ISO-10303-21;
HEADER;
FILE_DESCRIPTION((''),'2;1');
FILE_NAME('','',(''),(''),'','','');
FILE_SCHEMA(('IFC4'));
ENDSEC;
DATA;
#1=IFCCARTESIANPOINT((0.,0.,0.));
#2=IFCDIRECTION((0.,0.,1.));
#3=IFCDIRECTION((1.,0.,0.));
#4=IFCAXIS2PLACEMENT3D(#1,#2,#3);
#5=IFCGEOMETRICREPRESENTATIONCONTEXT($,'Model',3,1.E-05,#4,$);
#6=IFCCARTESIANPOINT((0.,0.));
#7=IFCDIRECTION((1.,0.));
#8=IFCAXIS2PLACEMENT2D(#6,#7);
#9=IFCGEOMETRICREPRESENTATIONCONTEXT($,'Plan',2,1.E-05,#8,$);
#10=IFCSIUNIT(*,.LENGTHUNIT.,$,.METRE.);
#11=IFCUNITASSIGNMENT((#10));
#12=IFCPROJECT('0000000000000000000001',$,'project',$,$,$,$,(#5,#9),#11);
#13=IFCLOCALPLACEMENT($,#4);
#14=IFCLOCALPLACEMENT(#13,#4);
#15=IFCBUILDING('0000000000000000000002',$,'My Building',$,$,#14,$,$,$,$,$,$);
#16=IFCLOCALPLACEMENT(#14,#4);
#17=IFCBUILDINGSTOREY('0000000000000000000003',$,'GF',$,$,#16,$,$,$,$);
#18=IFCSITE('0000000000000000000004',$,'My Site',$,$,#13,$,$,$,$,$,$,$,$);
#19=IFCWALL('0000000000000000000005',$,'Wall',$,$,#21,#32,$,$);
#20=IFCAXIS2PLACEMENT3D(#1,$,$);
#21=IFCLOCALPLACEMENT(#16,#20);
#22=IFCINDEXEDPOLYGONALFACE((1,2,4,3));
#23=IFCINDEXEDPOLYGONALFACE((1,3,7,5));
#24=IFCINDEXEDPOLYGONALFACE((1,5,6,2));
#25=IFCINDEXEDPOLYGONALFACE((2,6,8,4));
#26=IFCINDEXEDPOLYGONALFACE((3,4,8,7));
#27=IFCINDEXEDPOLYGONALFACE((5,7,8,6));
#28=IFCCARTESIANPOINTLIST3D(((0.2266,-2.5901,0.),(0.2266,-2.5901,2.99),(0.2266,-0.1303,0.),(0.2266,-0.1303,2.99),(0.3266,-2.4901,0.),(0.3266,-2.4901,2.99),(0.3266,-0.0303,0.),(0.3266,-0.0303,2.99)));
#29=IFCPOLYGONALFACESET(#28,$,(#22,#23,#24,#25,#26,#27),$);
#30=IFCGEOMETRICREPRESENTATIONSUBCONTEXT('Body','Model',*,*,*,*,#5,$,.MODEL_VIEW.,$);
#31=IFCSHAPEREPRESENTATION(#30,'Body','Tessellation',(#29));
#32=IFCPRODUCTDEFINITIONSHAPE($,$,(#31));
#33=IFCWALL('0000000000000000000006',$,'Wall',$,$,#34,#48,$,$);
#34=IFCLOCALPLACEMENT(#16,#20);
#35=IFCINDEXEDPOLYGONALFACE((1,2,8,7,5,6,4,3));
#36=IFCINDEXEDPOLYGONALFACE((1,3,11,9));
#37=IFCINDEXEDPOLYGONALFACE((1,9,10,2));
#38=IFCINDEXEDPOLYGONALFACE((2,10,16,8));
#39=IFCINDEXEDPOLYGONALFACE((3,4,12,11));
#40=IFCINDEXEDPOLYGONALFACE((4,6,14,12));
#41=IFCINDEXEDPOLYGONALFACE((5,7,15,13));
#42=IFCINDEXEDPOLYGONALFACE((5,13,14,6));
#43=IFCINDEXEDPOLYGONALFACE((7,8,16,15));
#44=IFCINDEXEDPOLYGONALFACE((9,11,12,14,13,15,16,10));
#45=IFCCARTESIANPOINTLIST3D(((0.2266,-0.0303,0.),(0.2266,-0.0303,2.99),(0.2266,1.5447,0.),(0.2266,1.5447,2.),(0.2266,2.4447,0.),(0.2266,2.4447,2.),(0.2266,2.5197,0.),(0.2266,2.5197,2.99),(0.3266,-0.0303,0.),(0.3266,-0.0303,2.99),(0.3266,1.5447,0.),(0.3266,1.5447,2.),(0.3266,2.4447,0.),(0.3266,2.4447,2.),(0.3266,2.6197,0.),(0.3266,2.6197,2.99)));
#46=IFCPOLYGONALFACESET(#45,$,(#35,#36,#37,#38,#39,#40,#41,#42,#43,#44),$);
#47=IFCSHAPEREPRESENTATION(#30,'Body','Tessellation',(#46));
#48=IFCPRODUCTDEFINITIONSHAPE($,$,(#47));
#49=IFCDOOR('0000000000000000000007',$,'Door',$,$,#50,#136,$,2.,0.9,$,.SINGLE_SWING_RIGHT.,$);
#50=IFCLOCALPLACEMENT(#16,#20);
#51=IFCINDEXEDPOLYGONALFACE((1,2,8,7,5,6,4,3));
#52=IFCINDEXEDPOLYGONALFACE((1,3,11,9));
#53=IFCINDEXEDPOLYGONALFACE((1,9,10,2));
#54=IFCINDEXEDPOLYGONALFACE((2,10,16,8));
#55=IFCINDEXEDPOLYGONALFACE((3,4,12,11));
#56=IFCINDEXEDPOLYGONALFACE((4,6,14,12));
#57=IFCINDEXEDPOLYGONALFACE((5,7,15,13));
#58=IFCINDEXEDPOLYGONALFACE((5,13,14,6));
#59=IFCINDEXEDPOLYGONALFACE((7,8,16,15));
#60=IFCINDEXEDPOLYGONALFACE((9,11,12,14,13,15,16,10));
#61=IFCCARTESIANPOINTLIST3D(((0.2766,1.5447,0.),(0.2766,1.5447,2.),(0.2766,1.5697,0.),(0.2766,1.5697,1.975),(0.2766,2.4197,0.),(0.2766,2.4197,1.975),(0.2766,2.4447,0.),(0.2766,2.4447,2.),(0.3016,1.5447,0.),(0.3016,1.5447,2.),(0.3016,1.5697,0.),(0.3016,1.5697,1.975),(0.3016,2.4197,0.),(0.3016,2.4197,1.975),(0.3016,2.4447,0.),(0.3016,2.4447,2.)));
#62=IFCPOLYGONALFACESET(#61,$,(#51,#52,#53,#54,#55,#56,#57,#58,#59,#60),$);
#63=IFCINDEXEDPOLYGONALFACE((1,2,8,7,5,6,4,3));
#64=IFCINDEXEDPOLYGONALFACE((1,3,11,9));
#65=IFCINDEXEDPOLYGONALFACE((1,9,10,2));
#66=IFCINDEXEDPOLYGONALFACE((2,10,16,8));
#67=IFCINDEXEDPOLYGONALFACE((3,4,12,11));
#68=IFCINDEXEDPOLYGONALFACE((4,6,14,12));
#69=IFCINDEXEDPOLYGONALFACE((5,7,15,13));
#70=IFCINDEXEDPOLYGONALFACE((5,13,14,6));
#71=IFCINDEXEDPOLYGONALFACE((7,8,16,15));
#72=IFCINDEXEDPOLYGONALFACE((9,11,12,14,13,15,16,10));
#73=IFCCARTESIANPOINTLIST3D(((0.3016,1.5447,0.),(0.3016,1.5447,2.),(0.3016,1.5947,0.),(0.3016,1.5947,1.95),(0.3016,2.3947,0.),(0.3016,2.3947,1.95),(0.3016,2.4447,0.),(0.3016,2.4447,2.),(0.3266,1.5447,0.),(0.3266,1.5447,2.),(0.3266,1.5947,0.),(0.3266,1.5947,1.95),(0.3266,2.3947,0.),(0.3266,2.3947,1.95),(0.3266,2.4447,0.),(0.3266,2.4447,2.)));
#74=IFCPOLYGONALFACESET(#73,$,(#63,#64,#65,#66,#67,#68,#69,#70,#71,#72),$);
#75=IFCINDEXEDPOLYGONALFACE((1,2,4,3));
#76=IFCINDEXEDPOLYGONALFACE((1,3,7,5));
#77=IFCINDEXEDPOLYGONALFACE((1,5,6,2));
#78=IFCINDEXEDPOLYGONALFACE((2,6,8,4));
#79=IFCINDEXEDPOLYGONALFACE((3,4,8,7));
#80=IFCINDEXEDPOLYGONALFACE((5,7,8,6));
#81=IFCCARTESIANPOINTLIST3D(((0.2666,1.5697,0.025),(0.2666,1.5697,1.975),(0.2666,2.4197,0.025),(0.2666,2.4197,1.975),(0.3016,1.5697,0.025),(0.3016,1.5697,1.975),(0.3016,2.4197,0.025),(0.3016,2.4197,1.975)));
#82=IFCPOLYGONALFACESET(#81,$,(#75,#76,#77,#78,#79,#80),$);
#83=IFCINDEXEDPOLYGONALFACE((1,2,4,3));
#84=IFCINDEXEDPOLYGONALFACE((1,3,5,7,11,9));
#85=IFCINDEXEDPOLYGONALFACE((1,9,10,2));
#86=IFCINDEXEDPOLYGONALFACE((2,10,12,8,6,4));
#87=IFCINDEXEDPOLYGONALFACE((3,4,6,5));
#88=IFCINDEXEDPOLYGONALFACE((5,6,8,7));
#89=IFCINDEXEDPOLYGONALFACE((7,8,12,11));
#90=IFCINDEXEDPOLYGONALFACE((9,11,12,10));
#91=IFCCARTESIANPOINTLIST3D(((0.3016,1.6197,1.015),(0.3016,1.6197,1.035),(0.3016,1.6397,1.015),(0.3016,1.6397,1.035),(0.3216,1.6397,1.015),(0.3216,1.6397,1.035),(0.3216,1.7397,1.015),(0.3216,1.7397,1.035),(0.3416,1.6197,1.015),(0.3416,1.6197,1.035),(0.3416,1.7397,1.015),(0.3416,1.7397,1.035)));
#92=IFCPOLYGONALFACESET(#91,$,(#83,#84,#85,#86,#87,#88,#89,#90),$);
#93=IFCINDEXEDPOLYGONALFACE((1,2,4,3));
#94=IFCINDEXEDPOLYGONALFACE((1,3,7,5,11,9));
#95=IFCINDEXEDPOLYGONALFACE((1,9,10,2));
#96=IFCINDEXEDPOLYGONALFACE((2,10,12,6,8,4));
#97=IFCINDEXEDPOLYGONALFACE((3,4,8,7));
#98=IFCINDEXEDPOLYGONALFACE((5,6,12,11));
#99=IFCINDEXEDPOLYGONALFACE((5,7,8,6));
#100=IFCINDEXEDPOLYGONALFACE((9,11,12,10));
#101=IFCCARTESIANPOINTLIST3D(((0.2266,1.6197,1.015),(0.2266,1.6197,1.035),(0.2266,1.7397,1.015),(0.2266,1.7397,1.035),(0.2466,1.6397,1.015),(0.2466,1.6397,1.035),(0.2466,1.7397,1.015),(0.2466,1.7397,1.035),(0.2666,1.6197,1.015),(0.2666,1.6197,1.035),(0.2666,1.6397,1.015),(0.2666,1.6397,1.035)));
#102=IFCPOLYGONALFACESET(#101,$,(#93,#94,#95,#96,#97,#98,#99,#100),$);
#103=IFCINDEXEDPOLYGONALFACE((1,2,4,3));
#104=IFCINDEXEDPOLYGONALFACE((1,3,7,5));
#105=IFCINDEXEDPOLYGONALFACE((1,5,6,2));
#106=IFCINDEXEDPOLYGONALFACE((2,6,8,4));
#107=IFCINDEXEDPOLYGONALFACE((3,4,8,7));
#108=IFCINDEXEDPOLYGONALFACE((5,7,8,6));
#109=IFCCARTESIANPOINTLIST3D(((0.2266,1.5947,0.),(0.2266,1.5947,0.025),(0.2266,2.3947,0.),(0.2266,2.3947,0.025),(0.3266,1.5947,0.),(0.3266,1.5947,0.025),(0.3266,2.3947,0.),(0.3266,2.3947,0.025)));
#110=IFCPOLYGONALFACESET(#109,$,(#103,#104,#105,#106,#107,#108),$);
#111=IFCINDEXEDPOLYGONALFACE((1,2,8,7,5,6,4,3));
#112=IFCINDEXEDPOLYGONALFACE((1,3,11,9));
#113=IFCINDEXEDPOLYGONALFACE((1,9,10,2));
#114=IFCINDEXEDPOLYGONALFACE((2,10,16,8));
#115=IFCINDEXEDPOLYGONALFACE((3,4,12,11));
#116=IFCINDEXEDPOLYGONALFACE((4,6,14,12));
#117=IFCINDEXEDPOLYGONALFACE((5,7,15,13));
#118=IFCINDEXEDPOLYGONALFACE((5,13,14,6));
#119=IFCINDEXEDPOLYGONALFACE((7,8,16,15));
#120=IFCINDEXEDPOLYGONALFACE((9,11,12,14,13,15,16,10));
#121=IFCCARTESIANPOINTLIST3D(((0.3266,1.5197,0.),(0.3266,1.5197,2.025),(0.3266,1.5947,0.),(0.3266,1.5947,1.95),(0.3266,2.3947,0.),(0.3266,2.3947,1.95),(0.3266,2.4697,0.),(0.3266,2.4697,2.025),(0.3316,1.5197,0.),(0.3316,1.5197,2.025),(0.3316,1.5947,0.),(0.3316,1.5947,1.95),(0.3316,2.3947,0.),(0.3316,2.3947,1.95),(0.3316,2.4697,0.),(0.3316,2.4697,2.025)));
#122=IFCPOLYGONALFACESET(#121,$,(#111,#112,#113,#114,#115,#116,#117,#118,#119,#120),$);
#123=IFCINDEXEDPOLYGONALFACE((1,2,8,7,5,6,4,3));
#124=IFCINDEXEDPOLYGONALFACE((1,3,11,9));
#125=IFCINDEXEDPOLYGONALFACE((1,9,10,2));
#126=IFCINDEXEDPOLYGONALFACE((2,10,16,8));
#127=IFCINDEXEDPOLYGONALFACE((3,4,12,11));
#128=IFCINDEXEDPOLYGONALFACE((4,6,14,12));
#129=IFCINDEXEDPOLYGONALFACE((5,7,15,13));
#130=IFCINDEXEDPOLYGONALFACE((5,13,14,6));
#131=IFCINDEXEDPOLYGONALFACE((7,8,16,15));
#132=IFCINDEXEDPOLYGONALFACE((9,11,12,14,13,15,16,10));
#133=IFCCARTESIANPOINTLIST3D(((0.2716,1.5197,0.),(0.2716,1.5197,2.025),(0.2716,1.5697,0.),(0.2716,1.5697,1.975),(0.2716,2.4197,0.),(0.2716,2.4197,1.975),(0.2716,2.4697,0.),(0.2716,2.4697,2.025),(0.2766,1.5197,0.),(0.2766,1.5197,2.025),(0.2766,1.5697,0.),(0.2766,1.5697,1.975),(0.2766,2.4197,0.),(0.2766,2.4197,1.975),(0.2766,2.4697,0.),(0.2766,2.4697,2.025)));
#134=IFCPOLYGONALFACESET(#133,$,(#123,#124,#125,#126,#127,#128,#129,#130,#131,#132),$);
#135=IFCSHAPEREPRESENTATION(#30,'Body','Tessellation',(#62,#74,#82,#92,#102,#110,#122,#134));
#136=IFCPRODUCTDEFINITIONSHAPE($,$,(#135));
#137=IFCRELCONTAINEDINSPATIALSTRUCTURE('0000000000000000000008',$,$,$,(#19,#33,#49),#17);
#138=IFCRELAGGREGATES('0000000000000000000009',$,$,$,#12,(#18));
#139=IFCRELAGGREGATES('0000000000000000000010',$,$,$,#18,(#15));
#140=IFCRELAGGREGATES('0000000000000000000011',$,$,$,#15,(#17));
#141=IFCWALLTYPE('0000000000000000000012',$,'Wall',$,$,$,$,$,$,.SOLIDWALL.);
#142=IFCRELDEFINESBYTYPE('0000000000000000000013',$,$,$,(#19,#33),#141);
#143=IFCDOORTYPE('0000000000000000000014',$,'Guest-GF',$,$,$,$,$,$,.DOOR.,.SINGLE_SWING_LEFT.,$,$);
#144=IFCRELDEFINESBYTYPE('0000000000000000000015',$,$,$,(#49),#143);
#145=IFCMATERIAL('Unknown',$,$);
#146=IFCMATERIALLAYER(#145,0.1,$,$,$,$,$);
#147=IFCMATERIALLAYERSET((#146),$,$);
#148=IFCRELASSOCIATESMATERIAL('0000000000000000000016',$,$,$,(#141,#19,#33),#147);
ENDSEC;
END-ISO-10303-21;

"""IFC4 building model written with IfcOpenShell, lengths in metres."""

from ifc_helpers import new_model, entity, si_unit, frame, origin_with_axes, origin_2d_with_axis, place, context, subcontext, project, spatial, line, indexed_curve, outline, extrude, shape, source, transform, mapped, material, layer, layer_set, layer_usage, type_object, type_shapes, element, fill, save


model = new_model("IFC4")

# Units and contexts
model_context = context("Model", 3, precision=1e-05, world=origin_with_axes())
plan_context = context("Plan", 2, precision=1e-05, world=origin_2d_with_axis())
body_context_1 = subcontext(model_context, "Body", "Model", "MODEL_VIEW")
body_context_2 = subcontext(plan_context, "Body", "Plan", "PLAN_VIEW")
ifc_project = project(units=[si_unit("LENGTHUNIT", "METRE")], contexts=[model_context, plan_context])

# Site, building, storey
site_placement = place(None, origin_with_axes())
site = spatial("IfcSite", under=ifc_project, at=site_placement, Name="My Site")
building_placement = place(site_placement, origin_with_axes())
building = spatial("IfcBuilding", under=site, at=building_placement, Name="My Building")
storey_placement = place(building_placement, origin_with_axes())
storey = spatial("IfcBuildingStorey", under=building, at=storey_placement, Name="GF")

# Shared definitions
ifc_material = material(Name="Unknown")

# Shared definitions
ifc_layer_1 = layer(ifc_material, 0.1)
ifc_layer_set_1 = layer_set([ifc_layer_1])
wall_type = type_object("IfcWallType", Name="Wall", PredefinedType="SOLIDWALL", material=ifc_layer_set_1)

# Wall
ifc_layer_usage_1 = layer_usage(ifc_layer_set_1, "AXIS2", "POSITIVE", 0.0)
wall_1_placement = place(storey_placement, frame((0.2266, -0.1303, 0.0), z_axis=(0.0, 0.0, 1.0), x_axis=(0.0, -1.0, 0.0)))
element("IfcWall", 1, at=wall_1_placement, inside=storey, type_object=wall_type, material=ifc_layer_usage_1, Name="Wall", context=body_context_1, shape_type="SweptSolid", body=[
    extrude(outline(indexed_curve([(0.0, 0.0), (-0.1, 0.1), (2.3598, 0.1), (2.4598, 0.0)], segments=[line(1, 2, 3, 4, 1)])), origin_with_axes(), (0.0, 0.0, 1.0), 2.99),
])

# Wall, opening, door
ifc_layer_usage_2 = layer_usage(ifc_layer_set_1, "AXIS2", "POSITIVE", 0.0)
wall_2_placement = place(storey_placement, frame((0.3266, -0.0303, 0.0), z_axis=(0.0, 0.0, 1.0), x_axis=(0.0, 1.0, 0.0)))
wall_2 = element("IfcWall", 2, at=wall_2_placement, inside=storey, type_object=wall_type, material=ifc_layer_usage_2, Name="Wall", context=body_context_1, shape_type="SweptSolid", body=[
    extrude(outline(indexed_curve([(0.0, 0.0), (0.0, 0.1), (2.55, 0.1), (2.65, 0.0)], segments=[line(1, 2, 3, 4, 1)])), origin_with_axes(), (0.0, 0.0, 1.0), 2.99),
])
shared_shape_1 = source(origin_with_axes(), body_context_1, "Body", "SweptSolid", [
    extrude(outline(indexed_curve([(0.0, 0.0), (0.9, 0.0), (0.9, 2.0), (0.0, 2.0)], segments=[line(1, 2, 3, 4, 1)])), frame((0.0, -0.6, 0.0), z_axis=(0.0, -1.0, 0.0), x_axis=(1.0, 0.0, 0.0)), (0.0, 0.0, -1.0), 1.2),
])
opening_1_placement = place(wall_2_placement, frame((1.575, 0.0, 0.0), z_axis=(0.0, 0.0, 1.0), x_axis=(1.0, 0.0, 0.0)))
opening_1 = element("IfcOpeningElement", 3, at=opening_1_placement, cuts=wall_2, PredefinedType="OPENING", context=body_context_1, shape_type="MappedRepresentation", body=[
    mapped(shared_shape_1, transform((0.0, 0.0, 0.0), x_axis=(1.0, 0.0, 0.0), y_axis=(0.0, 1.0, 0.0), z_axis=(0.0, 0.0, 1.0), scale=1.0)),
])
door_type_1 = type_object("IfcDoorType", Name="Guest-GF", OperationType="SINGLE_SWING_LEFT", PredefinedType="DOOR")
shared_shape_2 = source(origin_with_axes(), body_context_1, "Body", "SweptSolid", [
    extrude(outline(indexed_curve([(0.0, 0.0), (0.0, 2.0), (0.9, 2.0), (0.9, 0.0), (0.875, 0.0), (0.875, 1.975), (0.025, 1.975), (0.025, 0.0)], segments=[line(1, 2, 3, 4, 5, 6, 7, 8, 1)])), frame((0.0, 0.025, 0.0), z_axis=(0.0, -1.0, 0.0), x_axis=(1.0, 0.0, 0.0)), (0.0, 0.0, -1.0), 0.025),
    extrude(outline(indexed_curve([(0.0, 0.0), (0.0, 2.0), (0.9, 2.0), (0.9, 0.0), (0.85, 0.0), (0.85, 1.95), (0.05, 1.95), (0.05, 0.0)], segments=[line(1, 2, 3, 4, 5, 6, 7, 8, 1)])), frame((0.0, 0.0, 0.0), z_axis=(0.0, -1.0, 0.0), x_axis=(1.0, 0.0, 0.0)), (0.0, 0.0, -1.0), 0.025),
    extrude(outline(indexed_curve([(0.0, 0.0), (0.85, 0.0), (0.85, 0.035), (0.0, 0.035)], segments=[line(1, 2, 3, 4, 1)])), frame((0.025, 0.025, 0.025), z_axis=(0.0, 0.0, 1.0), x_axis=(1.0, 0.0, 0.0)), (0.0, 0.0, 1.0), 1.95),
    extrude(outline(indexed_curve([(0.0, 0.0), (0.0, -0.04), (0.12, -0.04), (0.12, -0.02), (0.02, -0.02), (0.02, 0.0)], segments=[line(1, 2, 3, 4, 5, 6, 1)])), frame((0.075, 0.025, 1.015), z_axis=(0.0, 0.0, 1.0), x_axis=(1.0, 0.0, 0.0)), (0.0, 0.0, 1.0), 0.02),
    extrude(outline(indexed_curve([(0.0, 0.0), (0.0, 0.04), (0.12, 0.04), (0.12, 0.02), (0.02, 0.02), (0.02, 0.0)], segments=[line(1, 2, 3, 4, 5, 6, 1)])), frame((0.075, 0.06, 1.015), z_axis=(0.0, 0.0, 1.0), x_axis=(1.0, 0.0, 0.0)), (0.0, 0.0, 1.0), 0.02),
    extrude(outline(indexed_curve([(0.0, 0.0), (0.8, 0.0), (0.8, 0.1), (0.0, 0.1)], segments=[line(1, 2, 3, 4, 1)])), frame((0.05, 0.0, 0.0), z_axis=(0.0, 0.0, 1.0), x_axis=(1.0, 0.0, 0.0)), (0.0, 0.0, 1.0), 0.025),
    extrude(outline(indexed_curve([(0.0, 0.0), (0.0, 2.025), (0.95, 2.025), (0.95, 0.0), (0.875, 0.0), (0.875, 1.95), (0.075, 1.95), (0.075, 0.0)], segments=[line(1, 2, 3, 4, 5, 6, 7, 8, 1)])), frame((-0.025, -0.005, 0.0), z_axis=(0.0, -1.0, 0.0), x_axis=(1.0, 0.0, 0.0)), (0.0, 0.0, -1.0), 0.005),
    extrude(outline(indexed_curve([(0.0, 0.0), (0.0, 2.025), (0.95, 2.025), (0.95, 0.0), (0.9, 0.0), (0.9, 1.975), (0.05, 1.975), (0.05, 0.0)], segments=[line(1, 2, 3, 4, 5, 6, 7, 8, 1)])), frame((-0.025, 0.05, 0.0), z_axis=(0.0, -1.0, 0.0), x_axis=(1.0, 0.0, 0.0)), (0.0, 0.0, -1.0), 0.005),
])
shared_shape_3 = source(origin_with_axes(), body_context_2, "Body", "Curve2D", [
    entity("IfcIndexedPolyCurve", entity("IfcCartesianPointList2D", [[0.0, 0.0], [0.0, 0.05], [0.025, 0.05], [0.025, 0.025], [0.05, 0.025], [0.05, 0.0]]), [entity("IfcLineIndex", [1, 2, 3, 4, 5, 6, 1])]),
    entity("IfcIndexedPolyCurve", entity("IfcCartesianPointList2D", [[0.9, 0.0], [0.9, 0.05], [0.875, 0.05], [0.875, 0.025], [0.85, 0.025], [0.85, 0.0]]), [entity("IfcLineIndex", [1, 2, 3, 4, 5, 6, 1])]),
    entity("IfcTrimmedCurve", entity("IfcEllipse", entity("IfcAxis2Placement2D", entity("IfcCartesianPoint", [0.84, 0.05]), entity("IfcDirection", [1.0, 0.0])), 0.815, 0.85), [entity("IfcCartesianPoint", [0.84, 0.9])], [entity("IfcCartesianPoint", [0.025, 0.05])], True, "CARTESIAN"),
    entity("IfcIndexedPolyCurve", entity("IfcCartesianPointList2D", [[0.875, 0.05], [0.84, 0.05], [0.84, 0.9], [0.875, 0.9]]), [entity("IfcLineIndex", [1, 2, 3, 4, 1])]),
])
type_shapes(door_type_1, [shared_shape_2, shared_shape_3])
door_1_placement = place(opening_1_placement, frame((0.0, 0.0, 0.0), z_axis=(0.0, 0.0, 1.0), x_axis=(1.0, 0.0, 0.0)))
door_1 = element("IfcDoor", 4, at=door_1_placement, inside=storey, type_object=door_type_1, Name="Door", OperationType="SINGLE_SWING_RIGHT", OverallHeight=2.0, OverallWidth=0.9, shapes=[
    shape(body_context_1, "Body", "MappedRepresentation", [mapped(shared_shape_2, transform((0.0, 0.0, 0.0), x_axis=(1.0, 0.0, 0.0), y_axis=(0.0, 1.0, 0.0), z_axis=(0.0, 0.0, 1.0), scale=1.0))]),
    shape(body_context_2, "Body", "MappedRepresentation", [mapped(shared_shape_3, transform((0.0, 0.0, 0.0), x_axis=(1.0, 0.0, 0.0), y_axis=(0.0, 1.0, 0.0), z_axis=(0.0, 0.0, 1.0), scale=1.0))]),
])
fill(opening_1, door_1)

save(model, "model.ifc")
